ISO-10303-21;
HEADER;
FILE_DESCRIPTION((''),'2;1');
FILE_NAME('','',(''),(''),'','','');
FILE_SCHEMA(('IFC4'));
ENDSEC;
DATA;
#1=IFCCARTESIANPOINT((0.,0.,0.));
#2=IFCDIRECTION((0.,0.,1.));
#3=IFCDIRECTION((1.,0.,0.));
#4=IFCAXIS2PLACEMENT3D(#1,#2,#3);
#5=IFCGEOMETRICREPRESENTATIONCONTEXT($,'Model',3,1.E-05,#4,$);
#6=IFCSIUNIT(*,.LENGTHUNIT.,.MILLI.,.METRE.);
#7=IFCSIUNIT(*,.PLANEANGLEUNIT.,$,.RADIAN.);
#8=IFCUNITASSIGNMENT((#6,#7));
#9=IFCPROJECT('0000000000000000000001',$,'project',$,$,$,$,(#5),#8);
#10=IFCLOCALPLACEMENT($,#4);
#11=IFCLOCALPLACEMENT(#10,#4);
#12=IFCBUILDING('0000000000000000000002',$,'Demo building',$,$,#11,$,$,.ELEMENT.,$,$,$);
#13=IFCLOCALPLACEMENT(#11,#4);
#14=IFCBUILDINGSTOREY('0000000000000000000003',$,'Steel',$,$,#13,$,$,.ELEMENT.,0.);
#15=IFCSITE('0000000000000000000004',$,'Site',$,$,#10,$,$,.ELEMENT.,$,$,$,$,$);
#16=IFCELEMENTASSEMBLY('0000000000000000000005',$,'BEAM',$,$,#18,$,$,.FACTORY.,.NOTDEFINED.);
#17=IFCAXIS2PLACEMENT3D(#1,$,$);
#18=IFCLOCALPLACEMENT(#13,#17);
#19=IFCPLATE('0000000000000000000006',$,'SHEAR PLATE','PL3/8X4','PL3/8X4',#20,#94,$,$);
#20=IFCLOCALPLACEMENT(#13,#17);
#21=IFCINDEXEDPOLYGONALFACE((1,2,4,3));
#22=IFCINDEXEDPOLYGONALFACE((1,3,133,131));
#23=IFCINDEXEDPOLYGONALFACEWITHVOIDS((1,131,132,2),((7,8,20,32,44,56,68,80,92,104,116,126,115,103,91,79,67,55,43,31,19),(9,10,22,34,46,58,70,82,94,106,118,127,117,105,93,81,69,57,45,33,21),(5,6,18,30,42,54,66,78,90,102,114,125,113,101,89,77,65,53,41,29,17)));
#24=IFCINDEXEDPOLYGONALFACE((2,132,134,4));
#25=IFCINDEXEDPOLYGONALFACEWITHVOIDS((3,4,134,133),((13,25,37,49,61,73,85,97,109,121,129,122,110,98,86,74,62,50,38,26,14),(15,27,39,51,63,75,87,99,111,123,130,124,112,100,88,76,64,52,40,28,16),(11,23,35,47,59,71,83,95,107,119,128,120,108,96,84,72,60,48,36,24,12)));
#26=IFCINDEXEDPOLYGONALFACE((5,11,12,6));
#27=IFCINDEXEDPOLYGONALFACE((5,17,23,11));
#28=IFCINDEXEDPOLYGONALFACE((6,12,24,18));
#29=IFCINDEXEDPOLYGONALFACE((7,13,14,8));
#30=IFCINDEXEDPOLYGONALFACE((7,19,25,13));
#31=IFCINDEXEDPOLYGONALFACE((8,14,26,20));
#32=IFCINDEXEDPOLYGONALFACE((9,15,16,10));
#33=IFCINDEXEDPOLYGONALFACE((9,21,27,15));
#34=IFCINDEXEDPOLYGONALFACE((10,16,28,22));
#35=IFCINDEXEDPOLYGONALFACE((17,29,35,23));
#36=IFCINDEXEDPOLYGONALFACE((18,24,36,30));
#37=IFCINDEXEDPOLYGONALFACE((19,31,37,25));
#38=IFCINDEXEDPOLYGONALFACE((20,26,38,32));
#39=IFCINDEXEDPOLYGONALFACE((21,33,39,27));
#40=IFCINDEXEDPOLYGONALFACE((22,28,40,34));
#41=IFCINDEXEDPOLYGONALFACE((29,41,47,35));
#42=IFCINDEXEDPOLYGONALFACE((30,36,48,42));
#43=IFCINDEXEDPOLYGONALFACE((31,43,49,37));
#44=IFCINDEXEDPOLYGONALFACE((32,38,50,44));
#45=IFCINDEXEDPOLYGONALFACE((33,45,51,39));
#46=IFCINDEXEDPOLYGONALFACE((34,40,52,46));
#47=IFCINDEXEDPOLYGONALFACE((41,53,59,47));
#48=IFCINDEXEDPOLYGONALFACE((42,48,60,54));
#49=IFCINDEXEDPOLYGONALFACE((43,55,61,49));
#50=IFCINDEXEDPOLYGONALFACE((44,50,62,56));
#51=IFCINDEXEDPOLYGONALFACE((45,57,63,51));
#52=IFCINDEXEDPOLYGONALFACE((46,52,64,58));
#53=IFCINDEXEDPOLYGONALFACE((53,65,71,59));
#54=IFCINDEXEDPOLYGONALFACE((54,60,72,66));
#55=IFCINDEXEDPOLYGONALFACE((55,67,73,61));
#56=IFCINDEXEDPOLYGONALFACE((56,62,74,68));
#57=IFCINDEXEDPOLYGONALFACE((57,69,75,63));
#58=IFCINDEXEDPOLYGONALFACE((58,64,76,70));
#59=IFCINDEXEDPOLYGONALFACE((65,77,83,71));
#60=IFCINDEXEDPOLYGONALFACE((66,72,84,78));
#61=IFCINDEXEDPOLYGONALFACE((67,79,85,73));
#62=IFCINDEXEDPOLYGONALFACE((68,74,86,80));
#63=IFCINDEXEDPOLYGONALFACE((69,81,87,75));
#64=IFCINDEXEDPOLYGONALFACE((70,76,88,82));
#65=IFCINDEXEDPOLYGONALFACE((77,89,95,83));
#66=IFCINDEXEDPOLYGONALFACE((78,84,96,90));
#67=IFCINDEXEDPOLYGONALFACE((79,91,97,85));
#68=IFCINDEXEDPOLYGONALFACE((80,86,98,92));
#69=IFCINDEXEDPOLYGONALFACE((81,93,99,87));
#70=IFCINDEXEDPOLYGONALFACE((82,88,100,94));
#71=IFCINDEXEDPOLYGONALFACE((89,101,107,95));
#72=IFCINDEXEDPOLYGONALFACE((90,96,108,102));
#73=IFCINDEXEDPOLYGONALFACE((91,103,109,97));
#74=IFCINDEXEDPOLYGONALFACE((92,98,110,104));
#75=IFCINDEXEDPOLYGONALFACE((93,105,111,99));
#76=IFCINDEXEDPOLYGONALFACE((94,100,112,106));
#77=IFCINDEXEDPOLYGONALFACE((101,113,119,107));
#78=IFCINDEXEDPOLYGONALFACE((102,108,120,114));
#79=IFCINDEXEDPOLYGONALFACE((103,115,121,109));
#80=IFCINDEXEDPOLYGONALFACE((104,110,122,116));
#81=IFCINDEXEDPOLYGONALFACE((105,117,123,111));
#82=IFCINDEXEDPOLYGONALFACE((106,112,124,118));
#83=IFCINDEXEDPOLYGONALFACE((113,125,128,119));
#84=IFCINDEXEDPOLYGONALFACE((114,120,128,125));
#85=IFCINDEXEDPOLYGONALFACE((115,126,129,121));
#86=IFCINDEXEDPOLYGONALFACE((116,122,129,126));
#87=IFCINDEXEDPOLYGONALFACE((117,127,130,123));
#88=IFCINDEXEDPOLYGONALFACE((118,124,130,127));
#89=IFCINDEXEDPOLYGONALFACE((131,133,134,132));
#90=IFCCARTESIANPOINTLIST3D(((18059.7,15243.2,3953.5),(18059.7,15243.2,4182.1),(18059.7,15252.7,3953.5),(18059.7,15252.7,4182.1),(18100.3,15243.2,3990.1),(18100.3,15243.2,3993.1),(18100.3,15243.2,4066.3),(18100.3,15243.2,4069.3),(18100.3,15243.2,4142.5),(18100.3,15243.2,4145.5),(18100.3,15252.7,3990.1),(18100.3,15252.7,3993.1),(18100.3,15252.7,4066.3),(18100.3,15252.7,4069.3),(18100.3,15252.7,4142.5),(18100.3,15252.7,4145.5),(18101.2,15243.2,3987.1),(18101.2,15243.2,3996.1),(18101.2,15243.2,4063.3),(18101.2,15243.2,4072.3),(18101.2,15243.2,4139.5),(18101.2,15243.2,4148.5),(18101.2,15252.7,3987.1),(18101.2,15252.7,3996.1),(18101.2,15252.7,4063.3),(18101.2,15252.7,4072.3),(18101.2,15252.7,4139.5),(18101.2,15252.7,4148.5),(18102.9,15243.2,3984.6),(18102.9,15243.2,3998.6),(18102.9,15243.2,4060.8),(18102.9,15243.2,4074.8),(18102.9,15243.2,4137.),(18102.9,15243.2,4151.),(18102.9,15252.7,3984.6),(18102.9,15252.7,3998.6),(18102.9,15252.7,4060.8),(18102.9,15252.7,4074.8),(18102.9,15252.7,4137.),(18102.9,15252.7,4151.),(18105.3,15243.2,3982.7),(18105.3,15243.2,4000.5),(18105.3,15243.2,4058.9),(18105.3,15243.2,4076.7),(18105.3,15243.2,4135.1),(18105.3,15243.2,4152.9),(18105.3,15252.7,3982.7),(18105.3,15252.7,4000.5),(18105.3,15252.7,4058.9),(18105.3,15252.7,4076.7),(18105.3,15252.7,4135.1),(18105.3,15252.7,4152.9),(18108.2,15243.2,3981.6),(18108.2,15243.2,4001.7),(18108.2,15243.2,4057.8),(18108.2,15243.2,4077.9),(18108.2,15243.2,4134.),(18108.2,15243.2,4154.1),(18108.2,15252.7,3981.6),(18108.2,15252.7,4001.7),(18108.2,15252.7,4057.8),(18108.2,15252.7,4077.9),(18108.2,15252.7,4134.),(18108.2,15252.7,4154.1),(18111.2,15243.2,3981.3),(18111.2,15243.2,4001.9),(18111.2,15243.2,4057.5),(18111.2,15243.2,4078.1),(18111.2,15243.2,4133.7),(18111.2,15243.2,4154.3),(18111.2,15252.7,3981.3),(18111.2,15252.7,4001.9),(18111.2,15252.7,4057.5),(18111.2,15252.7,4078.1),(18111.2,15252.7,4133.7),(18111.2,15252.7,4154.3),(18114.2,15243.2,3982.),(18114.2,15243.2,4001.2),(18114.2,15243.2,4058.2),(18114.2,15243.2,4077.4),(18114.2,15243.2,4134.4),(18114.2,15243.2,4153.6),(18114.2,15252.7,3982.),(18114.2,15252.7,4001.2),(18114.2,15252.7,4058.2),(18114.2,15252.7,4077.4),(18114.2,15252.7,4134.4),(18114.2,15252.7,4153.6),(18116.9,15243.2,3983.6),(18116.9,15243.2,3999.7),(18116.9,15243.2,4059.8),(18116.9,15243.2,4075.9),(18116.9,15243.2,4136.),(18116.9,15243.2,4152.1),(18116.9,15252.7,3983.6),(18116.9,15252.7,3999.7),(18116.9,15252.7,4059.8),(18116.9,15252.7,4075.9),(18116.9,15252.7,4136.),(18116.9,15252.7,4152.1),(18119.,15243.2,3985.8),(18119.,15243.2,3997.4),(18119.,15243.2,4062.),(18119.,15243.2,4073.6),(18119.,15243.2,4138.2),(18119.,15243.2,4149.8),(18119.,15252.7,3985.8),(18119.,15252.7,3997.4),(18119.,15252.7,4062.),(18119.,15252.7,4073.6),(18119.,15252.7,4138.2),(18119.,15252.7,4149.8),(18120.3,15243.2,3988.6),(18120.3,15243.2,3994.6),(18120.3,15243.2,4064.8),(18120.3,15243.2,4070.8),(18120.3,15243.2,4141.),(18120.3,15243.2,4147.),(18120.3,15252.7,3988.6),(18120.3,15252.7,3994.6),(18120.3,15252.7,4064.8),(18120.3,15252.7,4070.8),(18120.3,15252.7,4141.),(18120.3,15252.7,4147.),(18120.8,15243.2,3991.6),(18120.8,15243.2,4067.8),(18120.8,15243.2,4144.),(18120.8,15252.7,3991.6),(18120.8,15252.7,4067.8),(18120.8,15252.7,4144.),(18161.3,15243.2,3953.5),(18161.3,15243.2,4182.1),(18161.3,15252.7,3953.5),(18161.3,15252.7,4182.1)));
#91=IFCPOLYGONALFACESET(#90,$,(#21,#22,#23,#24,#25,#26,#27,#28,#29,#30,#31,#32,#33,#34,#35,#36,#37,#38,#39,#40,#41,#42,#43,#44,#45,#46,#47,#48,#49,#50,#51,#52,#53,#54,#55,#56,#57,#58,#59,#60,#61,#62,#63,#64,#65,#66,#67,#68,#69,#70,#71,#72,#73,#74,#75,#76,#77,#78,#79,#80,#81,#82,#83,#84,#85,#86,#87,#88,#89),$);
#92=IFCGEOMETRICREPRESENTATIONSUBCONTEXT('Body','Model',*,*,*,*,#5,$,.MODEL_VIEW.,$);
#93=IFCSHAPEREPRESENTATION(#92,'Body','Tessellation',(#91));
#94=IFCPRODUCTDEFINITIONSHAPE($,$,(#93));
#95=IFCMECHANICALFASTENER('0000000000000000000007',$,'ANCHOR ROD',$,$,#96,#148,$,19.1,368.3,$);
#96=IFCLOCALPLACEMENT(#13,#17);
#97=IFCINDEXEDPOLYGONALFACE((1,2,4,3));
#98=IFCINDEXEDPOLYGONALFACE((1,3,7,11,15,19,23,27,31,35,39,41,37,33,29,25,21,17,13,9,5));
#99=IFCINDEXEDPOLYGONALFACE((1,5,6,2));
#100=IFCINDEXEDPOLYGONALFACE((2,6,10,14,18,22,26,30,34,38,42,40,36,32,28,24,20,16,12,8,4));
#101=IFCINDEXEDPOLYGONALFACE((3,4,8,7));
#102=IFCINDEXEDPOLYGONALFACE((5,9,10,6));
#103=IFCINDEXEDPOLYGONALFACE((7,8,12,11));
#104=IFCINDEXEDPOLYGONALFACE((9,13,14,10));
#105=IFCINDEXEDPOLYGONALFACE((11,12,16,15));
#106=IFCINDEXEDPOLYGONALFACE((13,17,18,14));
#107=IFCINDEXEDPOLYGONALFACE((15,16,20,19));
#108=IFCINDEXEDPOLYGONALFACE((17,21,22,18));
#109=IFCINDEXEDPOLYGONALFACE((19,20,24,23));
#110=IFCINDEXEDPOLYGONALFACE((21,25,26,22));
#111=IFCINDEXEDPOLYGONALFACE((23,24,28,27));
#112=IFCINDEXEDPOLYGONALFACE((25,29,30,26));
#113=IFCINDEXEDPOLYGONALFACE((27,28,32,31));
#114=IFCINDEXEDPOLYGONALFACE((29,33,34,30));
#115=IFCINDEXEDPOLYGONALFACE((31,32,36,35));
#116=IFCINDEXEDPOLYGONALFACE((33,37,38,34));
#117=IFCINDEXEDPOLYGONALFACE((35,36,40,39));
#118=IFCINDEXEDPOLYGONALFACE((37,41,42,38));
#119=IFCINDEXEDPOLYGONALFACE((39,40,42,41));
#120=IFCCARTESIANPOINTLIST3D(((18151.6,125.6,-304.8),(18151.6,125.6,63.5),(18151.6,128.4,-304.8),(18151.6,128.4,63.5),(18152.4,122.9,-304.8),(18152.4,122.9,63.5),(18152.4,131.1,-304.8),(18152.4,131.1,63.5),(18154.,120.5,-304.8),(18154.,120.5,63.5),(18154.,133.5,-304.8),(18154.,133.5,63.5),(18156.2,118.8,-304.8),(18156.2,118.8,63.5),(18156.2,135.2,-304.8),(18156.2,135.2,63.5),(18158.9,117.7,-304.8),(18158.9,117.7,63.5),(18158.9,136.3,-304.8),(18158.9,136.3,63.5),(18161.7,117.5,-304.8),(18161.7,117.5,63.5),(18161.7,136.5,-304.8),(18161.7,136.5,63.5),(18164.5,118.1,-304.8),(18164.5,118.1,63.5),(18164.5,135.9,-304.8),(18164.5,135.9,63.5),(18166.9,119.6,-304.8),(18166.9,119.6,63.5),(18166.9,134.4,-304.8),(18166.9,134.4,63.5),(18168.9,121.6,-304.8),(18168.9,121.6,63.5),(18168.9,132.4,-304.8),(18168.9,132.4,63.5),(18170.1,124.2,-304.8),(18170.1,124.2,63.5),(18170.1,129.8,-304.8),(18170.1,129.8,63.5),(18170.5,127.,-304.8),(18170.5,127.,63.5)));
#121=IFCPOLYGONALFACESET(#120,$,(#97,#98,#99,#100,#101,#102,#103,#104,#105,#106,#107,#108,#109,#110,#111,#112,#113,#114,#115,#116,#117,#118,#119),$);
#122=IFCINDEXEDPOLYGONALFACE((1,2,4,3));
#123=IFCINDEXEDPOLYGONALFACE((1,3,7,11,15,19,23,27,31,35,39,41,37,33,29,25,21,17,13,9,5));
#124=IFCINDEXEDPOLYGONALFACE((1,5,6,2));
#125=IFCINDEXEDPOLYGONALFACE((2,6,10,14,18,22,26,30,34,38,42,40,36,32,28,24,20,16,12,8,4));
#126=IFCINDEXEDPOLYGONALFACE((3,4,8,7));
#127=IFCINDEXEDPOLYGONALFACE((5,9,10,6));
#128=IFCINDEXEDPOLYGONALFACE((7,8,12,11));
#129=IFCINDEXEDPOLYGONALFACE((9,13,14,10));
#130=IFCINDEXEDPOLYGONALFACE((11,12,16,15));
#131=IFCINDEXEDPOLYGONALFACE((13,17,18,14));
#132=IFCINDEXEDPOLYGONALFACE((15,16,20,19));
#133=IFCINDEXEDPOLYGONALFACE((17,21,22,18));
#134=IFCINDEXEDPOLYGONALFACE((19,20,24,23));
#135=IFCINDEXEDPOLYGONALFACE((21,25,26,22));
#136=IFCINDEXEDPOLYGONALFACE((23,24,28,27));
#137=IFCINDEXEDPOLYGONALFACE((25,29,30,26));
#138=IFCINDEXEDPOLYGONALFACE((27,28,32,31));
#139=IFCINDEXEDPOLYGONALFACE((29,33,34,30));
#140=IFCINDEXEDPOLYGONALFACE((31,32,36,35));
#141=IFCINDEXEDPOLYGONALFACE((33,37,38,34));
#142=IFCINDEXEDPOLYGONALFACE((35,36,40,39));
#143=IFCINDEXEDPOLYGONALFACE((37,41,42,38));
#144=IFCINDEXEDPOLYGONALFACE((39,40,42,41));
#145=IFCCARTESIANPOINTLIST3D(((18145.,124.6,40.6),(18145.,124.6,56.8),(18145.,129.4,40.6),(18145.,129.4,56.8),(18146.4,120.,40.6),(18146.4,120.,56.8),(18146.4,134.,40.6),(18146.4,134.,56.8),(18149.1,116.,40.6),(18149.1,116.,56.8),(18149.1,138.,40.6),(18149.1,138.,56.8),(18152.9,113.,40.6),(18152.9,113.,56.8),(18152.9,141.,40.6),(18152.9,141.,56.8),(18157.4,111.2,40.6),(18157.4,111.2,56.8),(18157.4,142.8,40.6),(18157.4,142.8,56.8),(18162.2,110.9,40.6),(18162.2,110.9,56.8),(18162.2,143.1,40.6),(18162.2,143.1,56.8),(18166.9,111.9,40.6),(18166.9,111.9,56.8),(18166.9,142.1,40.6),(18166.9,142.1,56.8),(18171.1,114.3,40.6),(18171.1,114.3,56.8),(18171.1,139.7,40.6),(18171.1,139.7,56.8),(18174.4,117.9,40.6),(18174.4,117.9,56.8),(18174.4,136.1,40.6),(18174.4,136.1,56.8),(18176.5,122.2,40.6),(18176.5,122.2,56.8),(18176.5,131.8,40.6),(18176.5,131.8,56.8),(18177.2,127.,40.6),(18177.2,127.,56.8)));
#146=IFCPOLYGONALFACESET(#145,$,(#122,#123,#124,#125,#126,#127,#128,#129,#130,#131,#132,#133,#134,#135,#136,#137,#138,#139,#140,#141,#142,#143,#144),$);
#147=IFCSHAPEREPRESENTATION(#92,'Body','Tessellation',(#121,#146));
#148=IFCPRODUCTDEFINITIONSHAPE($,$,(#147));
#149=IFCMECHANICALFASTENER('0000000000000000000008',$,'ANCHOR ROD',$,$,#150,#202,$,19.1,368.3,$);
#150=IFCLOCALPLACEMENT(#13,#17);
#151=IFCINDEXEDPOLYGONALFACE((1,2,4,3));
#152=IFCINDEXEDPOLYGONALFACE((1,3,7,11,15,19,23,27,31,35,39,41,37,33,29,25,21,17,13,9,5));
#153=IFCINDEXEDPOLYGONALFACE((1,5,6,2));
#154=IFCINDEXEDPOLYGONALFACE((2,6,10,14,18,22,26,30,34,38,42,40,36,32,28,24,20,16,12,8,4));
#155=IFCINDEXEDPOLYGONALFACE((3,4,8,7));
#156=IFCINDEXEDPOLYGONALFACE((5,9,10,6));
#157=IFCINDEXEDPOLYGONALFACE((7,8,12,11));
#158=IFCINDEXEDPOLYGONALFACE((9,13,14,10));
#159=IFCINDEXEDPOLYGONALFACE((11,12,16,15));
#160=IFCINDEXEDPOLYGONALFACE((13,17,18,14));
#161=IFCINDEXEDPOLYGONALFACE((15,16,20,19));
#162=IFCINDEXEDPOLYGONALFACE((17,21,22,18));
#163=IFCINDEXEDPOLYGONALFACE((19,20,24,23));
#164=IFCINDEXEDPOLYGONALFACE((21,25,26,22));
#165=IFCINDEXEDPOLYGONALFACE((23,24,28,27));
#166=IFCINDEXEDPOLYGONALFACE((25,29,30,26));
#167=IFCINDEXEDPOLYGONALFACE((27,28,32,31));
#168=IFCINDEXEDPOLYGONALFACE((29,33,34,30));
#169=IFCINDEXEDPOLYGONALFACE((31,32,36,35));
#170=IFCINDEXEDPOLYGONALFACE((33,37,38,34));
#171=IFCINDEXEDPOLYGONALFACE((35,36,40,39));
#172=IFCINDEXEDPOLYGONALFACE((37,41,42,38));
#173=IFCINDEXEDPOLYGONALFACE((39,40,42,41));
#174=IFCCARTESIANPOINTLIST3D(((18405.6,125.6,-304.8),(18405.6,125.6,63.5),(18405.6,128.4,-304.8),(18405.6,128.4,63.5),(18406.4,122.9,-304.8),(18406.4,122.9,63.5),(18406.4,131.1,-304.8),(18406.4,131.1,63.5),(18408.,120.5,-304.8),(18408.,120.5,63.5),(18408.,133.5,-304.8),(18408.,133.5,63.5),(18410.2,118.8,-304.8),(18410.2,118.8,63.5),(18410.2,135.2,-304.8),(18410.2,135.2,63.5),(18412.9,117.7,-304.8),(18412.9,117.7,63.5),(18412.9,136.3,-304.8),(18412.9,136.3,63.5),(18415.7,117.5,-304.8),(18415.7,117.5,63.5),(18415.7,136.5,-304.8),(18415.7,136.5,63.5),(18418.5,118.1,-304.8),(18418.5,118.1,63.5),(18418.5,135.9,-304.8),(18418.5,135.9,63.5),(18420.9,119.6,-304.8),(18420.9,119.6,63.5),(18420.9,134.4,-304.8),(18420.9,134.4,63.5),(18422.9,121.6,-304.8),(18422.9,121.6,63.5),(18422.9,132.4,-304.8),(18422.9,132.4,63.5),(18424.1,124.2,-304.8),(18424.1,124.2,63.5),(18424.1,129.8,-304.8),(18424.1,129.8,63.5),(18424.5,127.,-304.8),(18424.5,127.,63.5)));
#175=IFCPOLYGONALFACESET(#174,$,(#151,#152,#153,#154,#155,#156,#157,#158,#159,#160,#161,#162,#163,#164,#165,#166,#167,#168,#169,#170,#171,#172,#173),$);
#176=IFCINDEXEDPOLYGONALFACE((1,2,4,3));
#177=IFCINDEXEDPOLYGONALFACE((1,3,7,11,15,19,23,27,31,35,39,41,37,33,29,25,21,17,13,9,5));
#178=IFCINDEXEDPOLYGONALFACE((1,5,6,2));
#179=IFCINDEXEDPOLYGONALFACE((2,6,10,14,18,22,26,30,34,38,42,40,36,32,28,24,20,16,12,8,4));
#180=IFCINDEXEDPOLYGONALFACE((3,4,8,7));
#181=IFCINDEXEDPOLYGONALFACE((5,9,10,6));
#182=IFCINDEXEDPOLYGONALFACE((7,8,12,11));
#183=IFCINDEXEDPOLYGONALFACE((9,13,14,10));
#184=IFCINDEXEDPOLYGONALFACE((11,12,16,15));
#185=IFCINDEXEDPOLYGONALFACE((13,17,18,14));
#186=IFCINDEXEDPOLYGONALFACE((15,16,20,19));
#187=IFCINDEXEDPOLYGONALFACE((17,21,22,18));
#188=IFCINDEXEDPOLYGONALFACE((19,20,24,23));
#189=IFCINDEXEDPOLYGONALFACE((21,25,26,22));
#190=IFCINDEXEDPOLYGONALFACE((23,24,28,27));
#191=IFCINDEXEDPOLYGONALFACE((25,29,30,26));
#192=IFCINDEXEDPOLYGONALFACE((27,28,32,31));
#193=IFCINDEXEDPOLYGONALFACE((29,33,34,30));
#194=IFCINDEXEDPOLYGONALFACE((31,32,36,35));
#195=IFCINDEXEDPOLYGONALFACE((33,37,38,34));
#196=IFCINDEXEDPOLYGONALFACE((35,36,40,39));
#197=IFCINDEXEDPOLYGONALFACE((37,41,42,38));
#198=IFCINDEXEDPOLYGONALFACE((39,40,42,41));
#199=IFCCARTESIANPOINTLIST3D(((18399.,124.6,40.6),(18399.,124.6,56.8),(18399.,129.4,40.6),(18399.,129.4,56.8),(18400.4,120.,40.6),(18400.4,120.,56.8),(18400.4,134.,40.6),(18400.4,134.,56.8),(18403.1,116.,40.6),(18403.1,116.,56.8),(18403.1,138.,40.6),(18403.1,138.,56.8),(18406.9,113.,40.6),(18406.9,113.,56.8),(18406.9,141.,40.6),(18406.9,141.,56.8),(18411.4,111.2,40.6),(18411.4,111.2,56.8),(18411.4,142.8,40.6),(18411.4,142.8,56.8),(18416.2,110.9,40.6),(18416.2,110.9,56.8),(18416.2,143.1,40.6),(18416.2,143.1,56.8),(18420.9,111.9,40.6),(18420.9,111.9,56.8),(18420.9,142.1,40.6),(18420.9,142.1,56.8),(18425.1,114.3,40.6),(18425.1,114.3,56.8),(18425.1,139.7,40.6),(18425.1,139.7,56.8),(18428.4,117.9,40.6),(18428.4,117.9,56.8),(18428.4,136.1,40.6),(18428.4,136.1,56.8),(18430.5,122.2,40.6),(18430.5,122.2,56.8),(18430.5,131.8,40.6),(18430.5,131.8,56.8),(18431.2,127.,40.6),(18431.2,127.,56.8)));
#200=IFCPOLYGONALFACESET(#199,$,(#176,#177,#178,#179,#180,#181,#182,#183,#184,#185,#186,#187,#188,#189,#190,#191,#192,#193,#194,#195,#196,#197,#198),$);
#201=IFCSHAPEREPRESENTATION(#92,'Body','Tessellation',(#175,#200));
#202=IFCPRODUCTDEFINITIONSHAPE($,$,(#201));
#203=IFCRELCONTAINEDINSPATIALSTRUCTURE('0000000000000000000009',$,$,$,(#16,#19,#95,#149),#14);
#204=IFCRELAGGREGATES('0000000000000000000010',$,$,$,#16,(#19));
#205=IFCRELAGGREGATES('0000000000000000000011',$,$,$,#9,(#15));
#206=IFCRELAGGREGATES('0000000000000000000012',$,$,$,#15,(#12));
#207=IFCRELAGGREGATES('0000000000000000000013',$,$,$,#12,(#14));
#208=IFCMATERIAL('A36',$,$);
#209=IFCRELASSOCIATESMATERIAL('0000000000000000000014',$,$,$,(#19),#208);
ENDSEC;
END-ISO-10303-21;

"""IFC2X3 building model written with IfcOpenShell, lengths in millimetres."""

from ifc_helpers import new_model, si_unit, frame, frame_2d, origin, origin_with_axes, origin_2d, place, context, subcontext, project, spatial, rectangle, circle, extrude, boolean, material, element, aggregate, save


model = new_model("IFC2X3")

# Units and contexts
model_context = context("Model", 3, precision=1e-05, world=origin_with_axes())
body_context = subcontext(model_context, "Body", "Model", "MODEL_VIEW")
ifc_project = project(units=[si_unit("LENGTHUNIT", "METRE", prefix="MILLI"), si_unit("PLANEANGLEUNIT", "RADIAN")], contexts=[model_context])

# Site, building, storey
site_placement = place(None, origin_with_axes())
site = spatial("IfcSite", under=ifc_project, at=site_placement, Name="Site", CompositionType="ELEMENT")
building_placement = place(site_placement, origin_with_axes())
building = spatial("IfcBuilding", under=site, at=building_placement, Name="Demo building", CompositionType="ELEMENT")
placement = place(building_placement, origin_with_axes())
storey = spatial("IfcBuildingStorey", under=building, at=placement, Name="Steel", CompositionType="ELEMENT", Elevation=0.0)

# Shared definitions
ifc_material_1 = material(Name="A36")

# Element assembly, plate
assembly_1 = element("IfcElementAssembly", 1, at=placement, inside=storey, Name="BEAM", AssemblyPlace="FACTORY", PredefinedType="NOTDEFINED")
plate_1_placement = place(placement, frame((18059.7, 15252.7, 3953.5), z_axis=(0.0, -1.0, 0.0), x_axis=(1.0, 0.0, 0.0)))
plate_1 = element("IfcPlate", 2, at=plate_1_placement, inside=storey, material=ifc_material_1, Name="SHEAR PLATE", Description="PL3/8X4", ObjectType="PL3/8X4", context=body_context, shape_type="CSG", body=[
    boolean("DIFFERENCE", boolean("DIFFERENCE", boolean("DIFFERENCE", extrude(rectangle(XDim=101.6, YDim=228.6, at=frame_2d((50.8, 114.3))), origin(), (0.0, 0.0, 1.0), 9.5), extrude(circle(Radius=10.3, at=frame_2d((50.8, 38.1))), frame((0.0, 0.0, -5.0)), (0.0, 0.0, 1.0), 19.5)), extrude(circle(Radius=10.3, at=frame_2d((50.8, 114.3))), frame((0.0, 0.0, -5.0)), (0.0, 0.0, 1.0), 19.5)), extrude(circle(Radius=10.3, at=frame_2d((50.8, 190.5))), frame((0.0, 0.0, -5.0)), (0.0, 0.0, 1.0), 19.5)),
])
aggregate(assembly_1, [plate_1])

# Mechanical fasteners
for number, where, z_axis, x_axis, name in (
    (3, (18161.0, 127.0, -304.8), (0.0, 0.0, 1.0), (1.0, 0.0, 0.0), "ANCHOR ROD"),
    (4, (18415.0, 127.0, -304.8), (0.0, 0.0, 1.0), (1.0, 0.0, 0.0), "ANCHOR ROD"),
):
    element("IfcMechanicalFastener", number, at=place(placement, frame(where, z_axis=z_axis, x_axis=x_axis)), inside=storey, Name=name, NominalDiameter=19.1, NominalLength=368.3, context=body_context, shape_type="SweptSolid", body=[
        extrude(circle(Radius=9.5, at=origin_2d()), origin(), (0.0, 0.0, 1.0), 368.3),
        extrude(circle(Radius=16.2, at=origin_2d()), frame((0.0, 0.0, 345.4)), (0.0, 0.0, 1.0), 16.2),
    ])

save(model, "model.ifc")
